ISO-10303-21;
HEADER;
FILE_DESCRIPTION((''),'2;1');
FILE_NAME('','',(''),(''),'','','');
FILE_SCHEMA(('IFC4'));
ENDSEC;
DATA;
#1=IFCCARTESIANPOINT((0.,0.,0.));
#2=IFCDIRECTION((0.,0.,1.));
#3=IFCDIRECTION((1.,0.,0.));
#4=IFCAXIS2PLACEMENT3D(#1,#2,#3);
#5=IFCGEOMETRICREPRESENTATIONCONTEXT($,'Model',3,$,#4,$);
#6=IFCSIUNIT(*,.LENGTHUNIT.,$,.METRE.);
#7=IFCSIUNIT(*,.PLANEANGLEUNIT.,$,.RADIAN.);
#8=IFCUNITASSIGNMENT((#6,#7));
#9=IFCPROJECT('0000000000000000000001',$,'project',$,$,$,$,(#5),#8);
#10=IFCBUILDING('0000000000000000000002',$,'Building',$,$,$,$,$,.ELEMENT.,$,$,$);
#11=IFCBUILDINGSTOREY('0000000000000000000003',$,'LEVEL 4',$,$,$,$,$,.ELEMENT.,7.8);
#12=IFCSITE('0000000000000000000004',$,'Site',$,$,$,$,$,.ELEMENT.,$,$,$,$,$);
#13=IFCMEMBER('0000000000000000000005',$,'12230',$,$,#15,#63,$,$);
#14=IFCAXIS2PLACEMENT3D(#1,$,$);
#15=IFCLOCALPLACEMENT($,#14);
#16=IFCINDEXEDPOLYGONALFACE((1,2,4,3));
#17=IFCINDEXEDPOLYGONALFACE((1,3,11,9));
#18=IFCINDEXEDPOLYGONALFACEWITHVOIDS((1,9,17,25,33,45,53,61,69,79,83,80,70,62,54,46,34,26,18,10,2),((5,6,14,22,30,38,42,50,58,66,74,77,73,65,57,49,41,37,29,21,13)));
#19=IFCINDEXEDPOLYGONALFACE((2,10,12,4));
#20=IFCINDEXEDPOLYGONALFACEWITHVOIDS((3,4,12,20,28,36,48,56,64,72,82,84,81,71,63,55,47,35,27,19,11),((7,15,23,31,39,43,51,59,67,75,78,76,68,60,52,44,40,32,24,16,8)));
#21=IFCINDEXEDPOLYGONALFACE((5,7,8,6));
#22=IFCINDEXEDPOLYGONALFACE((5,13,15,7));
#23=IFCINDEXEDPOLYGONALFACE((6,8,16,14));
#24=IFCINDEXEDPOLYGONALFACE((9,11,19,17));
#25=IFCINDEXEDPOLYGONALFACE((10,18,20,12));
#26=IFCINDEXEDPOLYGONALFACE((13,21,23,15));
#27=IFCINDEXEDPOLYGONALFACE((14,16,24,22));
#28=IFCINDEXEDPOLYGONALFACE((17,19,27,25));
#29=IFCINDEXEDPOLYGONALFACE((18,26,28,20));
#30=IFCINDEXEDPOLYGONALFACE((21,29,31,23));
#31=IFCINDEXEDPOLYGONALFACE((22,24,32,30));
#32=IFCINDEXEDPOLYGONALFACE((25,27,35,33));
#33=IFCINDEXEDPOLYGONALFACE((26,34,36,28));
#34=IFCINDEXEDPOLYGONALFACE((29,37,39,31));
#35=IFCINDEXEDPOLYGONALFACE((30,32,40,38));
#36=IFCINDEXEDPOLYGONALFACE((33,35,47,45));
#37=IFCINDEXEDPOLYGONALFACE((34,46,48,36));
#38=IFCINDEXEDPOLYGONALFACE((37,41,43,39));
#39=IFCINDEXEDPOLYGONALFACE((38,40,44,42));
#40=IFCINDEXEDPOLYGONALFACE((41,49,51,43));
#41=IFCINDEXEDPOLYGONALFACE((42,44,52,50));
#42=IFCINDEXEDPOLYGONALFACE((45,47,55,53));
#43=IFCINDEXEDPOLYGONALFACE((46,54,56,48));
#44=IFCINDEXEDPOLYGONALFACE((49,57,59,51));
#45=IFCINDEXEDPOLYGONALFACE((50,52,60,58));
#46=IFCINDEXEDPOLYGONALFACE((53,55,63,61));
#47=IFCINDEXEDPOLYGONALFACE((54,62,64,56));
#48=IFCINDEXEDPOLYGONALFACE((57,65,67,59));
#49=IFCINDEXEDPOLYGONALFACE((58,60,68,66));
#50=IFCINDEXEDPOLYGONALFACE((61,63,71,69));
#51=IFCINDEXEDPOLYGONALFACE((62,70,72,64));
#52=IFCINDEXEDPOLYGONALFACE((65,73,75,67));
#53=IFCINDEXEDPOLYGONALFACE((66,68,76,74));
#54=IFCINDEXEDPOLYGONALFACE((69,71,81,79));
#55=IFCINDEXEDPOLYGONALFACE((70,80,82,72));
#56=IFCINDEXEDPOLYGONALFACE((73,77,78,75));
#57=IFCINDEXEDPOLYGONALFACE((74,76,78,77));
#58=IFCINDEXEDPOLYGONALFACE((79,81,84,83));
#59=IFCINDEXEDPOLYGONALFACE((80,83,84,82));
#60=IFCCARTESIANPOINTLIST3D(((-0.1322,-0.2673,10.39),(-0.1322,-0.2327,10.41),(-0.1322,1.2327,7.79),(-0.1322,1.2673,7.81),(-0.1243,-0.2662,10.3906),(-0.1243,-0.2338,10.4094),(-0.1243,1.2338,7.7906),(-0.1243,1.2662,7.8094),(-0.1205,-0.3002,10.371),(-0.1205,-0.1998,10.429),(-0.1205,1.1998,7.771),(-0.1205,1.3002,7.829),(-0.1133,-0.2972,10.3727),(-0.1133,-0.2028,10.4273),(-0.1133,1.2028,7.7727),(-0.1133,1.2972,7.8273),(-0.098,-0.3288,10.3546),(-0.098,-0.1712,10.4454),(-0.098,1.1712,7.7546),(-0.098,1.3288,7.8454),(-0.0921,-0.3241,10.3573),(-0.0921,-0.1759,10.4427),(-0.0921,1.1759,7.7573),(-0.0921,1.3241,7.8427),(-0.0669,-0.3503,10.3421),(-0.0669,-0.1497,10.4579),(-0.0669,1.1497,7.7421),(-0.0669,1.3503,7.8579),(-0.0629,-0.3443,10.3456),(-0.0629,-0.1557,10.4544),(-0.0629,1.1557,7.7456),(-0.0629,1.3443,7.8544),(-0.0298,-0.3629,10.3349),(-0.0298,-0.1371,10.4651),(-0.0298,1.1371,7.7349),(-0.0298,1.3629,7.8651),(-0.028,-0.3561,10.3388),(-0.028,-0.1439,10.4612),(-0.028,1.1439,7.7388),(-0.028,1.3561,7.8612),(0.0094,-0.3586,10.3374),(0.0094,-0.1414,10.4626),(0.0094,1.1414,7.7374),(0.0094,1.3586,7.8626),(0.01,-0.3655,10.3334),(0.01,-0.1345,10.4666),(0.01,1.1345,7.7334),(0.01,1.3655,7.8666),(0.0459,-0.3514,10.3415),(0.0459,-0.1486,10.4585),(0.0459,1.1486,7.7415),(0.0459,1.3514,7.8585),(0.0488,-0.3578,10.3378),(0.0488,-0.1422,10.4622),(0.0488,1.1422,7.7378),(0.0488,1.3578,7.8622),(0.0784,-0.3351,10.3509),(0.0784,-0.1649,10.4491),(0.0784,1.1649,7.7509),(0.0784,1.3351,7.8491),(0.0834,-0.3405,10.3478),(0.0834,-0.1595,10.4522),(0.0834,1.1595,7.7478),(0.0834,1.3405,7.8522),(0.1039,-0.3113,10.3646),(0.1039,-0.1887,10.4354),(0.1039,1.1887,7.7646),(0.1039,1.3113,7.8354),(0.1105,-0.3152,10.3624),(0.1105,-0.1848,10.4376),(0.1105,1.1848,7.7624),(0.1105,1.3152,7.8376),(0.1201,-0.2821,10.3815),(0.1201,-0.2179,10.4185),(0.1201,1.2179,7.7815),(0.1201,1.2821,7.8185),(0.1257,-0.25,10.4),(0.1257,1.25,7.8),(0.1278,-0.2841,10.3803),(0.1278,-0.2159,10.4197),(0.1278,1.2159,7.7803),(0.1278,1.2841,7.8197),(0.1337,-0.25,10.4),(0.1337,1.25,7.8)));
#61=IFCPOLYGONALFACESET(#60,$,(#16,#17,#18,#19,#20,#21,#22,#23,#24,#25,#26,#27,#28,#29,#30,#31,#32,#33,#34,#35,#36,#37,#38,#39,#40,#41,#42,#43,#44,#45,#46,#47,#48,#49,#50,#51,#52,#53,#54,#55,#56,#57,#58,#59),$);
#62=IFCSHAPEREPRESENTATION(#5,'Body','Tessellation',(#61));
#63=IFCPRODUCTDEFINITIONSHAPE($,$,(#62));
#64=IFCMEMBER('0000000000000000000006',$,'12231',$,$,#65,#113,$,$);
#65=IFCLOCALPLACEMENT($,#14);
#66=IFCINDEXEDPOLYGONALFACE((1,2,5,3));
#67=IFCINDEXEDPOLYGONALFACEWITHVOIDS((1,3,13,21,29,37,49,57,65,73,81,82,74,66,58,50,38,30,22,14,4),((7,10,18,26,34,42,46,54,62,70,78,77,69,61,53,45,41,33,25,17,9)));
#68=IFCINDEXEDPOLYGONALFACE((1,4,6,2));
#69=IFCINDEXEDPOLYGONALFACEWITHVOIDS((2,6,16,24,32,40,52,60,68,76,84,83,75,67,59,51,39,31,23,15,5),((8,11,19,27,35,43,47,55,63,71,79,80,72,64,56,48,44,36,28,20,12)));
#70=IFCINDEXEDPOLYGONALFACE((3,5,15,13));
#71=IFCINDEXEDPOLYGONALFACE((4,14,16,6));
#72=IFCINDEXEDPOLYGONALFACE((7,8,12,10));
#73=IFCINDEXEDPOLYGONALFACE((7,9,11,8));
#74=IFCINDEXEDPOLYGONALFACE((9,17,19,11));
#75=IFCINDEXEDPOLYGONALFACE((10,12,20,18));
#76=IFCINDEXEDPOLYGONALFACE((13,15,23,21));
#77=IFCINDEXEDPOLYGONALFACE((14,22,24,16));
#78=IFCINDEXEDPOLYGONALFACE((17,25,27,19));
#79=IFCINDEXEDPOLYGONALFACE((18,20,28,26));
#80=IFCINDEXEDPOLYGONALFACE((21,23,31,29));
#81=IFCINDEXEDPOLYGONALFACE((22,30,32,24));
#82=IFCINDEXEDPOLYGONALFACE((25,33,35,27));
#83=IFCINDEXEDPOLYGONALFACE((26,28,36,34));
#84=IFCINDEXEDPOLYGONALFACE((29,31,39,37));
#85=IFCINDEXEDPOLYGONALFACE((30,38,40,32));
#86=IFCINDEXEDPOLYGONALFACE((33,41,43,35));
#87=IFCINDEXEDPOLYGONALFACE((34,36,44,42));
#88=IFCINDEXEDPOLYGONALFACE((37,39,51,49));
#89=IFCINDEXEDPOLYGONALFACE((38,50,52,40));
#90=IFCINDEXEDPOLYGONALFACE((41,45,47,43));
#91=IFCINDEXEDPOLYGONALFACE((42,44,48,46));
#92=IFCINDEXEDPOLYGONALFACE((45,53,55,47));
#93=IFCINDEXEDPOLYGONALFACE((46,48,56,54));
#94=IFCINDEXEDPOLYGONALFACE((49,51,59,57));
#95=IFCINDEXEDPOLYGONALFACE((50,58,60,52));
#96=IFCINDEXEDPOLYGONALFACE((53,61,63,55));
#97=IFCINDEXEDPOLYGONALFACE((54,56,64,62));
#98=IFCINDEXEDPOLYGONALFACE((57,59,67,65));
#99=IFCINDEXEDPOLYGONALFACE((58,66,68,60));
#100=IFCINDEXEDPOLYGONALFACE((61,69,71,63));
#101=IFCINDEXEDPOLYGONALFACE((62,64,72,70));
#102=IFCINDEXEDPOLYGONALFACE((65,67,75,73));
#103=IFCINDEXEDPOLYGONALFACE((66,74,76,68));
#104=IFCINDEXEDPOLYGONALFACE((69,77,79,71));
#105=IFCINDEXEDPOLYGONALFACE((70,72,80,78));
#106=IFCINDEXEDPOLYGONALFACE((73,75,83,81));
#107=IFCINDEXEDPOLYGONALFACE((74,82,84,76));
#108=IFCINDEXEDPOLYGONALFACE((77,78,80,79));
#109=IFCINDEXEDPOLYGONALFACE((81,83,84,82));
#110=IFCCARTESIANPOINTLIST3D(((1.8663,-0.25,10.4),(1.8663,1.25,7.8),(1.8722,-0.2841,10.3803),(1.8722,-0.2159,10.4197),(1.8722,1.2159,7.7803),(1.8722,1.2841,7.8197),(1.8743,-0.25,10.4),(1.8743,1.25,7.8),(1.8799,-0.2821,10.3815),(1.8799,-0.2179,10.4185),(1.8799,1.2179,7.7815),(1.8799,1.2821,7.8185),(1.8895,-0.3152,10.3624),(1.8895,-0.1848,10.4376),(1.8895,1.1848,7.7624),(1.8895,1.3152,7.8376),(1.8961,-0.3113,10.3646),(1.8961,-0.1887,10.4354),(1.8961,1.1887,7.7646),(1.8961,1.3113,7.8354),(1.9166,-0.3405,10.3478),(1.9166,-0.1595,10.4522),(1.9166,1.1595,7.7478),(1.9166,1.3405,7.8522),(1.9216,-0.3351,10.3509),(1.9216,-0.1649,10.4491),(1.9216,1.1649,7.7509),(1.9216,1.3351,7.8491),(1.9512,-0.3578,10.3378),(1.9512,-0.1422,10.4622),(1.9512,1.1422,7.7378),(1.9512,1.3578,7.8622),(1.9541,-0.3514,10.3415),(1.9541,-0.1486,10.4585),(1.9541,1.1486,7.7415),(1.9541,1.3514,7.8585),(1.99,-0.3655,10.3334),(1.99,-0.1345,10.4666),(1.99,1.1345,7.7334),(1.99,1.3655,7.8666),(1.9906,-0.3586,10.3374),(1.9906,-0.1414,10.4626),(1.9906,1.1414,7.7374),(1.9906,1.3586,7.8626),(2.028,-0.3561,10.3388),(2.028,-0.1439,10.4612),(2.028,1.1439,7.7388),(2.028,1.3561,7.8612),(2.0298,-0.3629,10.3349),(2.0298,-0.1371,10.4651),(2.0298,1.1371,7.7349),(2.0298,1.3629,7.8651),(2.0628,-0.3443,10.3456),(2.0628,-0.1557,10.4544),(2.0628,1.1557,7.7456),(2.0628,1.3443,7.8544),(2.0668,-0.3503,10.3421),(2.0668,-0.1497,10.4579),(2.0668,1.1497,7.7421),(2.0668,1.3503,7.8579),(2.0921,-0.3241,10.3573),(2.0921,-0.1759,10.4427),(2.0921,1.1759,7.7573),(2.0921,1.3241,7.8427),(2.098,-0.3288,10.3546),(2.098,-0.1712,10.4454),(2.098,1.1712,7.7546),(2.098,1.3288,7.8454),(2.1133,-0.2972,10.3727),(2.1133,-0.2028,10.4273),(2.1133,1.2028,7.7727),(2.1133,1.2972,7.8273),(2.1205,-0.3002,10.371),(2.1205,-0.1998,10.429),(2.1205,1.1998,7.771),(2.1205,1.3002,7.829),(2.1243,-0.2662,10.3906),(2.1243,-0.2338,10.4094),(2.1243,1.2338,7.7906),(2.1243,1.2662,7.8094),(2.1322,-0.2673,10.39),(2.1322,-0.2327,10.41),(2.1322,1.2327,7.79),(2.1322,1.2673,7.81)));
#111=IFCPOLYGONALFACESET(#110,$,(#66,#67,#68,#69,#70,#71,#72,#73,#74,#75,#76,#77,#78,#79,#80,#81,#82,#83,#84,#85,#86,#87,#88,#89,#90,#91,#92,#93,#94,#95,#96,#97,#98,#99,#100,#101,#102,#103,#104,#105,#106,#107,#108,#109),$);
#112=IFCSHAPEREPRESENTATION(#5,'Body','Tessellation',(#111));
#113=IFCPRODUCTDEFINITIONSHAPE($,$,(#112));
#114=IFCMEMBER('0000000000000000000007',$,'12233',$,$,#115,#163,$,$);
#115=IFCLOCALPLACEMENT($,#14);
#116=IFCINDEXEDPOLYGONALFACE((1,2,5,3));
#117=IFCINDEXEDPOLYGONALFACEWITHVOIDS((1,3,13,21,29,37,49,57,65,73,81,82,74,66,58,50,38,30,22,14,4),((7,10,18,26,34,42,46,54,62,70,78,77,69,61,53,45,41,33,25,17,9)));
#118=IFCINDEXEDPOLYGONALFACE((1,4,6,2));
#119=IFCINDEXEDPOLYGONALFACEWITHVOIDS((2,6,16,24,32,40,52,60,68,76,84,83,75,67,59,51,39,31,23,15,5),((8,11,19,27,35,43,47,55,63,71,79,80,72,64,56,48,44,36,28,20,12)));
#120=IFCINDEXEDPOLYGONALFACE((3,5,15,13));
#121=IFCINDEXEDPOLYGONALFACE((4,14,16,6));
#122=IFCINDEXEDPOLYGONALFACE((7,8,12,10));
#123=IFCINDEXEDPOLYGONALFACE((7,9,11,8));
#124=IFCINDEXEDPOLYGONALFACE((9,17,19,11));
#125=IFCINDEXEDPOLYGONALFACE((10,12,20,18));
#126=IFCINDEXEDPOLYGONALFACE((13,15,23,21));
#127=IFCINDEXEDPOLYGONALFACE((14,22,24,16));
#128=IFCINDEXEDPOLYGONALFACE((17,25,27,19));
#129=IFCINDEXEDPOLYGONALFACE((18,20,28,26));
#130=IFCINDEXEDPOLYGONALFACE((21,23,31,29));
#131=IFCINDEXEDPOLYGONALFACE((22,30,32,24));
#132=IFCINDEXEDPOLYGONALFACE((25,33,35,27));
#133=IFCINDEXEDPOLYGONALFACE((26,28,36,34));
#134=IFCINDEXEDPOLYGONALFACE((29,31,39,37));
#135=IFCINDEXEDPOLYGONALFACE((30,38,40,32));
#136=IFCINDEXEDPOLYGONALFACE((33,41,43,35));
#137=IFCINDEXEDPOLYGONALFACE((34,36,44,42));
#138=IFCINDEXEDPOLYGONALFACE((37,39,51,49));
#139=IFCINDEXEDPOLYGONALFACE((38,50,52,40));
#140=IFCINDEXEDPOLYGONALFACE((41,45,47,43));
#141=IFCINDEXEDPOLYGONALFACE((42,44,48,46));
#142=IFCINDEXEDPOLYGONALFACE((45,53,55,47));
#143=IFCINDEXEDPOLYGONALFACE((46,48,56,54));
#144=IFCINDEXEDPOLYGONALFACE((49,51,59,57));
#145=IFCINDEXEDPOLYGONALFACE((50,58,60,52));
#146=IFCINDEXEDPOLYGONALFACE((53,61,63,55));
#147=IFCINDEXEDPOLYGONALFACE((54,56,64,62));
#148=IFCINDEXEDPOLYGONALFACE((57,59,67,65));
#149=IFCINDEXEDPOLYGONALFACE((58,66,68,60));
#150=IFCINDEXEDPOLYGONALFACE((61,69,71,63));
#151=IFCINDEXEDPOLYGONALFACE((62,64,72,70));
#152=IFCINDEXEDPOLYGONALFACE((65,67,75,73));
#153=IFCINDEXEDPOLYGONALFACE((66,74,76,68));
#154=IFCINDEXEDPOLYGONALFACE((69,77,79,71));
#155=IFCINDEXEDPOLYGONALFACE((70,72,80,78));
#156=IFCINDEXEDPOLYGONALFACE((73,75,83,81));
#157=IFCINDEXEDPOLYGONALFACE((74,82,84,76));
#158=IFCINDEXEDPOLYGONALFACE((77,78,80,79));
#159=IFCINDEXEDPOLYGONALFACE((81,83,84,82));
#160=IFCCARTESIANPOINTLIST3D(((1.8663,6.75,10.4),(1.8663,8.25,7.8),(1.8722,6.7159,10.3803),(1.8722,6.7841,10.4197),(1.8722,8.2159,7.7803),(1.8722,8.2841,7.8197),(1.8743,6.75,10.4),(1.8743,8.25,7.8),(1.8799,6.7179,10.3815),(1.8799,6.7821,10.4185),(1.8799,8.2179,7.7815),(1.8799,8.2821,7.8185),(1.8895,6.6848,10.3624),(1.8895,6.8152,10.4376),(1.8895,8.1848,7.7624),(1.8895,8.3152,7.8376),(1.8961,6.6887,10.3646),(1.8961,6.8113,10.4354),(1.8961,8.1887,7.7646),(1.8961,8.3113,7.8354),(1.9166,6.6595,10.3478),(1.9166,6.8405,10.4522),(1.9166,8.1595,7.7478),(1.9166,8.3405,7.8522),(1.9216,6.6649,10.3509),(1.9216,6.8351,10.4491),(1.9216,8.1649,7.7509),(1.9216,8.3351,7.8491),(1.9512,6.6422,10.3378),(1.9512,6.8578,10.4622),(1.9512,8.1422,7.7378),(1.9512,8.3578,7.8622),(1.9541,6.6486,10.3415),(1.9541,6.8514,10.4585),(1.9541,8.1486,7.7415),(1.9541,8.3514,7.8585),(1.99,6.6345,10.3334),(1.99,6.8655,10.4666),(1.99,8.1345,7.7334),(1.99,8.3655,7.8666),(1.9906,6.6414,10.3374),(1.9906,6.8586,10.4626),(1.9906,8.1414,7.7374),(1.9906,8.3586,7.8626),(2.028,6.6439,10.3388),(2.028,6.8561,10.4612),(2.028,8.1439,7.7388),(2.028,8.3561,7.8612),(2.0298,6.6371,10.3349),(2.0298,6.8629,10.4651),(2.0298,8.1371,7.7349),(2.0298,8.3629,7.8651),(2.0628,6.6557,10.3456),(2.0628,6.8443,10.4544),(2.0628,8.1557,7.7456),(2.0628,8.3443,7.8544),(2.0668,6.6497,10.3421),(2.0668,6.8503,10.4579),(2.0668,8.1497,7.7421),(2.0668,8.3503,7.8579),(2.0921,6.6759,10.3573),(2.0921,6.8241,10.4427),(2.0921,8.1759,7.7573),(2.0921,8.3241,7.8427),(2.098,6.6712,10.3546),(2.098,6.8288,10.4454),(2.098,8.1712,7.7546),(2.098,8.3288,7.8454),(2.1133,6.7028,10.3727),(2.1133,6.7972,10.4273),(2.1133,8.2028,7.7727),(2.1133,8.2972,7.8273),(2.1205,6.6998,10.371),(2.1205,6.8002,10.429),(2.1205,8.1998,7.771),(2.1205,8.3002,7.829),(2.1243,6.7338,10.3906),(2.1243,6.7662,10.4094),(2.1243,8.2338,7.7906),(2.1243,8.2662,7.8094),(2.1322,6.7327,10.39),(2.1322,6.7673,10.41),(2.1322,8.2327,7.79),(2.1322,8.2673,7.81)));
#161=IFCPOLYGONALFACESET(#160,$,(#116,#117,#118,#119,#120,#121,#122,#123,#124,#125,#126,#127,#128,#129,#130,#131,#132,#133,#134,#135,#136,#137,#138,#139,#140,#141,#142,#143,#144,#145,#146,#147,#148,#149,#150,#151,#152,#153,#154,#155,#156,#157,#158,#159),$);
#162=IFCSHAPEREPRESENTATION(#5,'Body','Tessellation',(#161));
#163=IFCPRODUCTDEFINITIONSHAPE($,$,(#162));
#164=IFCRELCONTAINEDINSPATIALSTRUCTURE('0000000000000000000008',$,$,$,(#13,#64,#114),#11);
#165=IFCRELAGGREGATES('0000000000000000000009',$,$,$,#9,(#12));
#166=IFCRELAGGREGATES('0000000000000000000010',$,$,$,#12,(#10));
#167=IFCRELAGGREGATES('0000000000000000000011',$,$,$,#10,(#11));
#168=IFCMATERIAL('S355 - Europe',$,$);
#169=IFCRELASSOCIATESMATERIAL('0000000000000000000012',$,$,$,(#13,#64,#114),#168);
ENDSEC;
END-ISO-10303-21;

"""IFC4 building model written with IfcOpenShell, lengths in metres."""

from ifc_helpers import new_model, si_unit, frame, origin_with_axes, origin_2d_with_axis, place, context, project, spatial, hollow_circle, extrude, material, material_profile, profile_set, profile_usage, element, save


model = new_model("IFC4")

# Units and contexts
model_context = context("Model", 3, world=origin_with_axes())
ifc_project = project(units=[si_unit("LENGTHUNIT", "METRE"), si_unit("PLANEANGLEUNIT", "RADIAN")], contexts=[model_context])

# Site, building, storey
site = spatial("IfcSite", under=ifc_project, Name="Site", CompositionType="ELEMENT")
building = spatial("IfcBuilding", under=site, Name="Building", CompositionType="ELEMENT")
storey = spatial("IfcBuildingStorey", under=building, Name="LEVEL 4", CompositionType="ELEMENT", Elevation=7.8)

# Shared definitions
ifc_material = material(Name="S355 - Europe")

# Members
ifc_material_profile_1 = material_profile(ifc_material, hollow_circle(Radius=0.1337, WallThickness=0.008, at=origin_2d_with_axis()))
ifc_profile_set_1 = profile_set([ifc_material_profile_1])
ifc_profile_usage_1 = profile_usage(ifc_profile_set_1, cardinal=10)
member_1_placement = place(None, frame((0.0, 1.25, 7.8), z_axis=(0.0, -0.499722, 0.866186), x_axis=(1.0, 0.0, 0.0)))
element("IfcMember", 1, at=member_1_placement, inside=storey, material=ifc_profile_usage_1, Name="12230", context=model_context, shape_type="SweptSolid", body=[
    extrude(hollow_circle(Radius=0.1337, WallThickness=0.008, at=origin_2d_with_axis()), origin_with_axes(), (0.0, 0.0, 1.0), 3.0017),
])
ifc_material_profile_2 = material_profile(ifc_material, hollow_circle(Radius=0.1337, WallThickness=0.008, at=origin_2d_with_axis()))
ifc_profile_set_2 = profile_set([ifc_material_profile_2])
ifc_profile_usage_2 = profile_usage(ifc_profile_set_2, cardinal=10)
member_2_placement = place(None, frame((2.0, -0.25, 10.4), z_axis=(0.0, 0.499722, -0.866186), x_axis=(-1.0, 0.0, 0.0)))
element("IfcMember", 2, at=member_2_placement, inside=storey, material=ifc_profile_usage_2, Name="12231", context=model_context, shape_type="SweptSolid", body=[
    extrude(hollow_circle(Radius=0.1337, WallThickness=0.008, at=origin_2d_with_axis()), origin_with_axes(), (0.0, 0.0, 1.0), 3.0017),
])
ifc_material_profile_3 = material_profile(ifc_material, hollow_circle(Radius=0.1337, WallThickness=0.008, at=origin_2d_with_axis()))
ifc_profile_set_3 = profile_set([ifc_material_profile_3])
ifc_profile_usage_3 = profile_usage(ifc_profile_set_3, cardinal=10)
member_3_placement = place(None, frame((2.0, 6.75, 10.4), z_axis=(0.0, 0.499722, -0.866186), x_axis=(-1.0, 0.0, 0.0)))
element("IfcMember", 3, at=member_3_placement, inside=storey, material=ifc_profile_usage_3, Name="12233", context=model_context, shape_type="SweptSolid", body=[
    extrude(hollow_circle(Radius=0.1337, WallThickness=0.008, at=origin_2d_with_axis()), origin_with_axes(), (0.0, 0.0, 1.0), 3.0017),
])

save(model, "model.ifc")
